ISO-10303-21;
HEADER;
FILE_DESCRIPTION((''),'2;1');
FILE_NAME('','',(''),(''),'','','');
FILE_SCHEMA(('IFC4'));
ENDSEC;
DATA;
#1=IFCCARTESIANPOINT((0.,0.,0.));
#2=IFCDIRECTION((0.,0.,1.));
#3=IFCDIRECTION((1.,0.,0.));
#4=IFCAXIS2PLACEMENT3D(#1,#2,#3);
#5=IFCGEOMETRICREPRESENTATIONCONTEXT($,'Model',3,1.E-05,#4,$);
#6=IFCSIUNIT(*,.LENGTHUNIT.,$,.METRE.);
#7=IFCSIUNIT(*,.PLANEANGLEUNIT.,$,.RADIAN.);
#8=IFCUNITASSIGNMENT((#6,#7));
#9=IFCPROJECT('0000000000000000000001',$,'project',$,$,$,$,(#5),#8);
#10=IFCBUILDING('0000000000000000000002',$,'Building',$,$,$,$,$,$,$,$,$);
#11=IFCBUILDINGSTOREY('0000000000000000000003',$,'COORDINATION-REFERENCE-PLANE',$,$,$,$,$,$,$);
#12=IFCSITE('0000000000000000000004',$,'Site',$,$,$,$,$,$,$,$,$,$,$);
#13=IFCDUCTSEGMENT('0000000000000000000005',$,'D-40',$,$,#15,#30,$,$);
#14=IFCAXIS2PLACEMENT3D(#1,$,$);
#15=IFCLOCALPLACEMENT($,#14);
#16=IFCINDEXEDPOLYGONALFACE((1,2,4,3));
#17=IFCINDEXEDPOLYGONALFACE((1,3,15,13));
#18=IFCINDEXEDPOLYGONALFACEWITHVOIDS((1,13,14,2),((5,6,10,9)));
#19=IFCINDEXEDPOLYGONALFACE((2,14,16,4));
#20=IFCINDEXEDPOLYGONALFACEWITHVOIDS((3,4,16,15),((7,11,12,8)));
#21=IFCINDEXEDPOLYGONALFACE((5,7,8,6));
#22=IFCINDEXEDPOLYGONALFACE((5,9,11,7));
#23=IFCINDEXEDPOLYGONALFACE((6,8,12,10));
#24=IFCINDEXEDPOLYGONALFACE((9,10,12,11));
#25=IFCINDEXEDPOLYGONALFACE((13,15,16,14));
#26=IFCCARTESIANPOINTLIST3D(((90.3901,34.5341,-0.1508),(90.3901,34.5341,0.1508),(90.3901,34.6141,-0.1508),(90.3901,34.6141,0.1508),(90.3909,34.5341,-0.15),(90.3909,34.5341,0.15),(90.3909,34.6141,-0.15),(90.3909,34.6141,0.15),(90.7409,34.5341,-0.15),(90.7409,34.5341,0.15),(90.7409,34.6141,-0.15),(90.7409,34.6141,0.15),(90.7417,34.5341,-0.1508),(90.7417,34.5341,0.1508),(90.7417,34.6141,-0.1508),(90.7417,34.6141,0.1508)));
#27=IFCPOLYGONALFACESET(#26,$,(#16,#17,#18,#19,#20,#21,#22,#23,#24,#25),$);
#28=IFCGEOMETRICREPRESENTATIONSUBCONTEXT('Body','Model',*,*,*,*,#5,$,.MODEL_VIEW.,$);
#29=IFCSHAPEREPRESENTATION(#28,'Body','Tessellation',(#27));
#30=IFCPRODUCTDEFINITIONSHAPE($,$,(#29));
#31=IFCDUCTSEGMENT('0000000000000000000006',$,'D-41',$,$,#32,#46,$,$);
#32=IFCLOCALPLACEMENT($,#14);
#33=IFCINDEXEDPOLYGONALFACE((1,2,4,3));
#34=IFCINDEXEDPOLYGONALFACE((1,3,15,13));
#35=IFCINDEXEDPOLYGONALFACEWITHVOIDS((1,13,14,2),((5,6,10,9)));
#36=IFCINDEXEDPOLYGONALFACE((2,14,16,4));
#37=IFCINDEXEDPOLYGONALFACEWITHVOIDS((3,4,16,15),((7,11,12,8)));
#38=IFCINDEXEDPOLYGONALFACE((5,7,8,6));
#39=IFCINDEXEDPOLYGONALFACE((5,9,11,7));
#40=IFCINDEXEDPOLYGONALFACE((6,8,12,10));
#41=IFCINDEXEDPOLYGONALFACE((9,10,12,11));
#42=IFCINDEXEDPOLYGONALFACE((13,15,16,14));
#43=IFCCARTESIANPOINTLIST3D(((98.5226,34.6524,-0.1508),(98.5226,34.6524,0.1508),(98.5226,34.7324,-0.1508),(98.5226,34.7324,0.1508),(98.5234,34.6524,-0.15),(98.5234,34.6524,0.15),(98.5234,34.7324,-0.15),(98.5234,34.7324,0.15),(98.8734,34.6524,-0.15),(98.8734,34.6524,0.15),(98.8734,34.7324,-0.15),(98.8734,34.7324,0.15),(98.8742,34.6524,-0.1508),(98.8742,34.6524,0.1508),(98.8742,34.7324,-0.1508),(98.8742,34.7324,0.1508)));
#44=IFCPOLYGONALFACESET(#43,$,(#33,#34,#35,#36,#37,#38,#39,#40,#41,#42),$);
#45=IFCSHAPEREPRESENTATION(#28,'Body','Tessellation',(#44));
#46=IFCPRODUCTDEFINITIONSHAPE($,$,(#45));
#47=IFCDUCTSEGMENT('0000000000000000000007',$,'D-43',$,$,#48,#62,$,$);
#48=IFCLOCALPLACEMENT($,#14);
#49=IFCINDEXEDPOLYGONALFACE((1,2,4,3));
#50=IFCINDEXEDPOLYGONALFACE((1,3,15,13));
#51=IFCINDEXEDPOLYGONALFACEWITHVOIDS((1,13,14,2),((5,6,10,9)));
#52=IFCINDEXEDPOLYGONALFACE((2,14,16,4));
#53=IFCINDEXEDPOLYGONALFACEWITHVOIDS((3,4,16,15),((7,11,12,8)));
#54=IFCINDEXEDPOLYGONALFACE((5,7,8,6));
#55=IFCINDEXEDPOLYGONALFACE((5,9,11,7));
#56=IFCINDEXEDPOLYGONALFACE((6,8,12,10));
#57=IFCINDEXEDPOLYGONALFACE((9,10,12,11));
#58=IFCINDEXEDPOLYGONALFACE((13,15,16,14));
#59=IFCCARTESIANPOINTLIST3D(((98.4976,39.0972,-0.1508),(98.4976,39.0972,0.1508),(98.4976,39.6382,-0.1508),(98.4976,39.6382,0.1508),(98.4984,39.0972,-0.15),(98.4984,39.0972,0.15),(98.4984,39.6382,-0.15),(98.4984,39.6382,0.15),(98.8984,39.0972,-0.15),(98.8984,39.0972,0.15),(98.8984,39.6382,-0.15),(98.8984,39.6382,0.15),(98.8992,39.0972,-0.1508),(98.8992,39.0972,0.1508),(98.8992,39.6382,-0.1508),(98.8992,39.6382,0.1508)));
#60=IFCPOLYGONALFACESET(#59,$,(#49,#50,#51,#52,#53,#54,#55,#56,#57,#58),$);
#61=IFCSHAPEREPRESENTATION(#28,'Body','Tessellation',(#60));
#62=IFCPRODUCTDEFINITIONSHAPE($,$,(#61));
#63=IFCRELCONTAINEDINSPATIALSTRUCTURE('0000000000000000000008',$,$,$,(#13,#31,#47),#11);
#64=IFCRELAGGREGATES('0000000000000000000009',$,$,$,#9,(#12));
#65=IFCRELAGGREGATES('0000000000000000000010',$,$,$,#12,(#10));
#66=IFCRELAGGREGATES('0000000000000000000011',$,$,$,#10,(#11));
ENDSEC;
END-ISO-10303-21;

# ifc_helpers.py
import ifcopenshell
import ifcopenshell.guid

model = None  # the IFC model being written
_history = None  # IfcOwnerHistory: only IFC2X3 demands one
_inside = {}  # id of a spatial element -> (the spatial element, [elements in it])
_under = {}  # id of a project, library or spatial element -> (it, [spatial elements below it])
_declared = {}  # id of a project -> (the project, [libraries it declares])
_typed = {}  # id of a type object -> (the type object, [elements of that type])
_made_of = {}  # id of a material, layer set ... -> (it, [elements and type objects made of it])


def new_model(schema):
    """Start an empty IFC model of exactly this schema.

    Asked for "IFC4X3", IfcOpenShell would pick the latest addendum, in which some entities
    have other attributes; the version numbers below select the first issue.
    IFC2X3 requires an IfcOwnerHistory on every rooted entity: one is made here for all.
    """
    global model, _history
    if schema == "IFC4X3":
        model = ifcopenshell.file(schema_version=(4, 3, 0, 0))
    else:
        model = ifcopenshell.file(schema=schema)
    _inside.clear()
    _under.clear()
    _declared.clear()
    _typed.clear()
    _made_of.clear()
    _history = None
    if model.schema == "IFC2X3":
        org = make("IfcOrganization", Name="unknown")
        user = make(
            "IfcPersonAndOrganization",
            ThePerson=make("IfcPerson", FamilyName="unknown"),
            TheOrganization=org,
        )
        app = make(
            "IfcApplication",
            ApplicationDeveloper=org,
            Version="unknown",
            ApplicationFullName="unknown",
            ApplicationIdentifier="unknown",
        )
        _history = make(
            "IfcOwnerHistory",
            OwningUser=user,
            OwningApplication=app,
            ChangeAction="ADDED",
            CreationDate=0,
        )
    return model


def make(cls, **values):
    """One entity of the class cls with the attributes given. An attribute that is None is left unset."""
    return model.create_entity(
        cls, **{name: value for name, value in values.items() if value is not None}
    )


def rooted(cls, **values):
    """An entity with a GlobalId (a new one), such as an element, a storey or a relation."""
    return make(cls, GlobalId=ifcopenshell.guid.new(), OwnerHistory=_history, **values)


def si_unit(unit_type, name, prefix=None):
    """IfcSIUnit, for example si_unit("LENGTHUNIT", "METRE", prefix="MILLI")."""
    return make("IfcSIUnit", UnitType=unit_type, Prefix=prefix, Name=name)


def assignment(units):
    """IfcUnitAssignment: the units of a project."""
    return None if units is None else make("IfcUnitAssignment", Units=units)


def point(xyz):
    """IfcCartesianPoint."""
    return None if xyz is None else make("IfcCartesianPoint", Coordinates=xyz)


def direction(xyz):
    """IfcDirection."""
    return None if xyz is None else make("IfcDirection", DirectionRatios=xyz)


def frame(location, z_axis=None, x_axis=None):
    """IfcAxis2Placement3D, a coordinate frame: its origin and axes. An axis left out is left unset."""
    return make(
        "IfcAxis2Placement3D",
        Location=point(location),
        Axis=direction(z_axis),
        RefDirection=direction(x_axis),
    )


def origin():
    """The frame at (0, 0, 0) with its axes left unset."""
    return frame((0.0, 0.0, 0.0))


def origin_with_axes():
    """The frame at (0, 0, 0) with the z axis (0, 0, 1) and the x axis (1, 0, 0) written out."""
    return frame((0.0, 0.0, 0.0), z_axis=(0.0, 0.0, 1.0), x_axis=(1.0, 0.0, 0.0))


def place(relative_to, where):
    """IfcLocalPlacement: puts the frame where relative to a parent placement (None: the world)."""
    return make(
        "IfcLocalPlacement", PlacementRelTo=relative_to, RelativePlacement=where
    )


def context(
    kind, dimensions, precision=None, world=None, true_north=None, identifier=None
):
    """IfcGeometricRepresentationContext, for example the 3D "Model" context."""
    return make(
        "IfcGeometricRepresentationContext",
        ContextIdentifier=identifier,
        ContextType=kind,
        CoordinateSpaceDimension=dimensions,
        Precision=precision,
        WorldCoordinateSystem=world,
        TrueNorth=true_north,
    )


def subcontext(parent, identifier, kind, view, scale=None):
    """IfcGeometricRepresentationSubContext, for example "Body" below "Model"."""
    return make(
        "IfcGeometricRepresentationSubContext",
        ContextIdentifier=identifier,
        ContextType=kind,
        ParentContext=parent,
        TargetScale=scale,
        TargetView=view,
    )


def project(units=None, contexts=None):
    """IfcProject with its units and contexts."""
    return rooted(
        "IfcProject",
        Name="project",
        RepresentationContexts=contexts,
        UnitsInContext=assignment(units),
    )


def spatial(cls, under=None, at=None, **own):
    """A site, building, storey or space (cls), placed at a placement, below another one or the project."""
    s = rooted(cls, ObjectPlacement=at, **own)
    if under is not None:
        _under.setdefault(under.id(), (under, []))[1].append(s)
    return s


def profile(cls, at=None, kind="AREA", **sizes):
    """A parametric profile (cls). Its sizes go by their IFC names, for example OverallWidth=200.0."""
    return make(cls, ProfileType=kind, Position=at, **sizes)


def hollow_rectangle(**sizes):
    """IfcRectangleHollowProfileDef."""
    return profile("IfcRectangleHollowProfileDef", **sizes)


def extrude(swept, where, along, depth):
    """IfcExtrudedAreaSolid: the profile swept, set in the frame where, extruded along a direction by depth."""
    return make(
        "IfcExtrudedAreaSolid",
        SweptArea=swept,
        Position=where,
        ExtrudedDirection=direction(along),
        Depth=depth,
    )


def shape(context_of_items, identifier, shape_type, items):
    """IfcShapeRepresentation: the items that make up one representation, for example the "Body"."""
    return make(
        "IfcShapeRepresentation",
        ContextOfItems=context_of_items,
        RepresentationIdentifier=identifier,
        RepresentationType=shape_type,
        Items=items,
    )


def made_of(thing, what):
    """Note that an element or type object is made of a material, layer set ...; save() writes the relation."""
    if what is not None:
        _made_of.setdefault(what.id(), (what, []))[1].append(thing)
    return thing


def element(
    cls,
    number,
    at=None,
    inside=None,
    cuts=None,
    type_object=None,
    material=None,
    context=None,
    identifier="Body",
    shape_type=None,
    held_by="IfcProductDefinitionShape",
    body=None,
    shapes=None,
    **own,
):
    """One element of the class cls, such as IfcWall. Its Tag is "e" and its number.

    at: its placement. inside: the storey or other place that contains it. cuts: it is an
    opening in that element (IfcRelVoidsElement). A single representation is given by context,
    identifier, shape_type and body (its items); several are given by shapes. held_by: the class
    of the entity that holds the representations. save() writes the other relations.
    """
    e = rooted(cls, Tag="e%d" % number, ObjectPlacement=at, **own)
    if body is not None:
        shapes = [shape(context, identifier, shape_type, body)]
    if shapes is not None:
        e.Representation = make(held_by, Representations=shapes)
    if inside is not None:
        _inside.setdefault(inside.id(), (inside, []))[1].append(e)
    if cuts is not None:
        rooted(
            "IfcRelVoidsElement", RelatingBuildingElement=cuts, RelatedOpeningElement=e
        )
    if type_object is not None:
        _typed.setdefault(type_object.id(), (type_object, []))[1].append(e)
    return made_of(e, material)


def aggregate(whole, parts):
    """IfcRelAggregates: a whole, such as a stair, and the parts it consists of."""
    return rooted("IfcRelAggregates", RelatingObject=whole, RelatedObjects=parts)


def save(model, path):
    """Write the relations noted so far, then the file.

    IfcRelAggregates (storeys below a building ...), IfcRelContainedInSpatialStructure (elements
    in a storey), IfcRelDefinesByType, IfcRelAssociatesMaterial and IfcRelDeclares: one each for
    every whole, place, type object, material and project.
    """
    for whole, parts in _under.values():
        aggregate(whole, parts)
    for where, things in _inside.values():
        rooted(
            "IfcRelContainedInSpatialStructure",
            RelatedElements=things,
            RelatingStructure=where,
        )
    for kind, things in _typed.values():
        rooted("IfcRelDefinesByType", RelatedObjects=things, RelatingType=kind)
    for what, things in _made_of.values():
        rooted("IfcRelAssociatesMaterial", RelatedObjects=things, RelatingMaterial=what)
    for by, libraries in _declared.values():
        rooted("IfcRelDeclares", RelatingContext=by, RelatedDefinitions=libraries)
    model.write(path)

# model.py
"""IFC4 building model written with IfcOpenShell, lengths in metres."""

from ifc_helpers import new_model, si_unit, frame, origin, origin_with_axes, place, context, subcontext, project, spatial, hollow_rectangle, extrude, element, save


model = new_model("IFC4")

# Units and contexts
model_context_1 = context("Model", 3, precision=1e-05, world=origin_with_axes())
body_context_1 = subcontext(model_context_1, "Body", "Model", "MODEL_VIEW")
ifc_project = project(units=[si_unit("LENGTHUNIT", "METRE"), si_unit("PLANEANGLEUNIT", "RADIAN")], contexts=[model_context_1])

# Site, building, storey
site = spatial("IfcSite", under=ifc_project, Name="Site")
building = spatial("IfcBuilding", under=site, Name="Building")
storey = spatial("IfcBuildingStorey", under=building, Name="COORDINATION-REFERENCE-PLANE")

# Duct segments
for number, where, z_axis, x_axis, name in (
    (1, (90.5659, 34.5341, 0.0), (0.0, 1.0, 0.0), (1.0, 0.0, 0.0), "D-40"),
    (2, (98.6984, 34.6524, 0.0), (0.0, 1.0, 0.0), (1.0, 0.0, 0.0), "D-41"),
):
    element("IfcDuctSegment", number, at=place(None, frame(where, z_axis=z_axis, x_axis=x_axis)), inside=storey, Name=name, context=body_context_1, shape_type="SweptSolid", body=[
        extrude(hollow_rectangle(XDim=0.3516, YDim=0.3016, WallThickness=0.0008), origin(), (0.0, 0.0, 1.0), 0.08),
    ])
duct_segment_1_placement = place(None, frame((98.6984, 39.0972, 0.0), z_axis=(0.0, 1.0, 0.0), x_axis=(1.0, 0.0, 0.0)))
element("IfcDuctSegment", 3, at=duct_segment_1_placement, inside=storey, Name="D-43", context=body_context_1, shape_type="SweptSolid", body=[
    extrude(hollow_rectangle(XDim=0.4016, YDim=0.3016, WallThickness=0.0008), origin(), (0.0, 0.0, 1.0), 0.541),
])

save(model, "model.ifc")
